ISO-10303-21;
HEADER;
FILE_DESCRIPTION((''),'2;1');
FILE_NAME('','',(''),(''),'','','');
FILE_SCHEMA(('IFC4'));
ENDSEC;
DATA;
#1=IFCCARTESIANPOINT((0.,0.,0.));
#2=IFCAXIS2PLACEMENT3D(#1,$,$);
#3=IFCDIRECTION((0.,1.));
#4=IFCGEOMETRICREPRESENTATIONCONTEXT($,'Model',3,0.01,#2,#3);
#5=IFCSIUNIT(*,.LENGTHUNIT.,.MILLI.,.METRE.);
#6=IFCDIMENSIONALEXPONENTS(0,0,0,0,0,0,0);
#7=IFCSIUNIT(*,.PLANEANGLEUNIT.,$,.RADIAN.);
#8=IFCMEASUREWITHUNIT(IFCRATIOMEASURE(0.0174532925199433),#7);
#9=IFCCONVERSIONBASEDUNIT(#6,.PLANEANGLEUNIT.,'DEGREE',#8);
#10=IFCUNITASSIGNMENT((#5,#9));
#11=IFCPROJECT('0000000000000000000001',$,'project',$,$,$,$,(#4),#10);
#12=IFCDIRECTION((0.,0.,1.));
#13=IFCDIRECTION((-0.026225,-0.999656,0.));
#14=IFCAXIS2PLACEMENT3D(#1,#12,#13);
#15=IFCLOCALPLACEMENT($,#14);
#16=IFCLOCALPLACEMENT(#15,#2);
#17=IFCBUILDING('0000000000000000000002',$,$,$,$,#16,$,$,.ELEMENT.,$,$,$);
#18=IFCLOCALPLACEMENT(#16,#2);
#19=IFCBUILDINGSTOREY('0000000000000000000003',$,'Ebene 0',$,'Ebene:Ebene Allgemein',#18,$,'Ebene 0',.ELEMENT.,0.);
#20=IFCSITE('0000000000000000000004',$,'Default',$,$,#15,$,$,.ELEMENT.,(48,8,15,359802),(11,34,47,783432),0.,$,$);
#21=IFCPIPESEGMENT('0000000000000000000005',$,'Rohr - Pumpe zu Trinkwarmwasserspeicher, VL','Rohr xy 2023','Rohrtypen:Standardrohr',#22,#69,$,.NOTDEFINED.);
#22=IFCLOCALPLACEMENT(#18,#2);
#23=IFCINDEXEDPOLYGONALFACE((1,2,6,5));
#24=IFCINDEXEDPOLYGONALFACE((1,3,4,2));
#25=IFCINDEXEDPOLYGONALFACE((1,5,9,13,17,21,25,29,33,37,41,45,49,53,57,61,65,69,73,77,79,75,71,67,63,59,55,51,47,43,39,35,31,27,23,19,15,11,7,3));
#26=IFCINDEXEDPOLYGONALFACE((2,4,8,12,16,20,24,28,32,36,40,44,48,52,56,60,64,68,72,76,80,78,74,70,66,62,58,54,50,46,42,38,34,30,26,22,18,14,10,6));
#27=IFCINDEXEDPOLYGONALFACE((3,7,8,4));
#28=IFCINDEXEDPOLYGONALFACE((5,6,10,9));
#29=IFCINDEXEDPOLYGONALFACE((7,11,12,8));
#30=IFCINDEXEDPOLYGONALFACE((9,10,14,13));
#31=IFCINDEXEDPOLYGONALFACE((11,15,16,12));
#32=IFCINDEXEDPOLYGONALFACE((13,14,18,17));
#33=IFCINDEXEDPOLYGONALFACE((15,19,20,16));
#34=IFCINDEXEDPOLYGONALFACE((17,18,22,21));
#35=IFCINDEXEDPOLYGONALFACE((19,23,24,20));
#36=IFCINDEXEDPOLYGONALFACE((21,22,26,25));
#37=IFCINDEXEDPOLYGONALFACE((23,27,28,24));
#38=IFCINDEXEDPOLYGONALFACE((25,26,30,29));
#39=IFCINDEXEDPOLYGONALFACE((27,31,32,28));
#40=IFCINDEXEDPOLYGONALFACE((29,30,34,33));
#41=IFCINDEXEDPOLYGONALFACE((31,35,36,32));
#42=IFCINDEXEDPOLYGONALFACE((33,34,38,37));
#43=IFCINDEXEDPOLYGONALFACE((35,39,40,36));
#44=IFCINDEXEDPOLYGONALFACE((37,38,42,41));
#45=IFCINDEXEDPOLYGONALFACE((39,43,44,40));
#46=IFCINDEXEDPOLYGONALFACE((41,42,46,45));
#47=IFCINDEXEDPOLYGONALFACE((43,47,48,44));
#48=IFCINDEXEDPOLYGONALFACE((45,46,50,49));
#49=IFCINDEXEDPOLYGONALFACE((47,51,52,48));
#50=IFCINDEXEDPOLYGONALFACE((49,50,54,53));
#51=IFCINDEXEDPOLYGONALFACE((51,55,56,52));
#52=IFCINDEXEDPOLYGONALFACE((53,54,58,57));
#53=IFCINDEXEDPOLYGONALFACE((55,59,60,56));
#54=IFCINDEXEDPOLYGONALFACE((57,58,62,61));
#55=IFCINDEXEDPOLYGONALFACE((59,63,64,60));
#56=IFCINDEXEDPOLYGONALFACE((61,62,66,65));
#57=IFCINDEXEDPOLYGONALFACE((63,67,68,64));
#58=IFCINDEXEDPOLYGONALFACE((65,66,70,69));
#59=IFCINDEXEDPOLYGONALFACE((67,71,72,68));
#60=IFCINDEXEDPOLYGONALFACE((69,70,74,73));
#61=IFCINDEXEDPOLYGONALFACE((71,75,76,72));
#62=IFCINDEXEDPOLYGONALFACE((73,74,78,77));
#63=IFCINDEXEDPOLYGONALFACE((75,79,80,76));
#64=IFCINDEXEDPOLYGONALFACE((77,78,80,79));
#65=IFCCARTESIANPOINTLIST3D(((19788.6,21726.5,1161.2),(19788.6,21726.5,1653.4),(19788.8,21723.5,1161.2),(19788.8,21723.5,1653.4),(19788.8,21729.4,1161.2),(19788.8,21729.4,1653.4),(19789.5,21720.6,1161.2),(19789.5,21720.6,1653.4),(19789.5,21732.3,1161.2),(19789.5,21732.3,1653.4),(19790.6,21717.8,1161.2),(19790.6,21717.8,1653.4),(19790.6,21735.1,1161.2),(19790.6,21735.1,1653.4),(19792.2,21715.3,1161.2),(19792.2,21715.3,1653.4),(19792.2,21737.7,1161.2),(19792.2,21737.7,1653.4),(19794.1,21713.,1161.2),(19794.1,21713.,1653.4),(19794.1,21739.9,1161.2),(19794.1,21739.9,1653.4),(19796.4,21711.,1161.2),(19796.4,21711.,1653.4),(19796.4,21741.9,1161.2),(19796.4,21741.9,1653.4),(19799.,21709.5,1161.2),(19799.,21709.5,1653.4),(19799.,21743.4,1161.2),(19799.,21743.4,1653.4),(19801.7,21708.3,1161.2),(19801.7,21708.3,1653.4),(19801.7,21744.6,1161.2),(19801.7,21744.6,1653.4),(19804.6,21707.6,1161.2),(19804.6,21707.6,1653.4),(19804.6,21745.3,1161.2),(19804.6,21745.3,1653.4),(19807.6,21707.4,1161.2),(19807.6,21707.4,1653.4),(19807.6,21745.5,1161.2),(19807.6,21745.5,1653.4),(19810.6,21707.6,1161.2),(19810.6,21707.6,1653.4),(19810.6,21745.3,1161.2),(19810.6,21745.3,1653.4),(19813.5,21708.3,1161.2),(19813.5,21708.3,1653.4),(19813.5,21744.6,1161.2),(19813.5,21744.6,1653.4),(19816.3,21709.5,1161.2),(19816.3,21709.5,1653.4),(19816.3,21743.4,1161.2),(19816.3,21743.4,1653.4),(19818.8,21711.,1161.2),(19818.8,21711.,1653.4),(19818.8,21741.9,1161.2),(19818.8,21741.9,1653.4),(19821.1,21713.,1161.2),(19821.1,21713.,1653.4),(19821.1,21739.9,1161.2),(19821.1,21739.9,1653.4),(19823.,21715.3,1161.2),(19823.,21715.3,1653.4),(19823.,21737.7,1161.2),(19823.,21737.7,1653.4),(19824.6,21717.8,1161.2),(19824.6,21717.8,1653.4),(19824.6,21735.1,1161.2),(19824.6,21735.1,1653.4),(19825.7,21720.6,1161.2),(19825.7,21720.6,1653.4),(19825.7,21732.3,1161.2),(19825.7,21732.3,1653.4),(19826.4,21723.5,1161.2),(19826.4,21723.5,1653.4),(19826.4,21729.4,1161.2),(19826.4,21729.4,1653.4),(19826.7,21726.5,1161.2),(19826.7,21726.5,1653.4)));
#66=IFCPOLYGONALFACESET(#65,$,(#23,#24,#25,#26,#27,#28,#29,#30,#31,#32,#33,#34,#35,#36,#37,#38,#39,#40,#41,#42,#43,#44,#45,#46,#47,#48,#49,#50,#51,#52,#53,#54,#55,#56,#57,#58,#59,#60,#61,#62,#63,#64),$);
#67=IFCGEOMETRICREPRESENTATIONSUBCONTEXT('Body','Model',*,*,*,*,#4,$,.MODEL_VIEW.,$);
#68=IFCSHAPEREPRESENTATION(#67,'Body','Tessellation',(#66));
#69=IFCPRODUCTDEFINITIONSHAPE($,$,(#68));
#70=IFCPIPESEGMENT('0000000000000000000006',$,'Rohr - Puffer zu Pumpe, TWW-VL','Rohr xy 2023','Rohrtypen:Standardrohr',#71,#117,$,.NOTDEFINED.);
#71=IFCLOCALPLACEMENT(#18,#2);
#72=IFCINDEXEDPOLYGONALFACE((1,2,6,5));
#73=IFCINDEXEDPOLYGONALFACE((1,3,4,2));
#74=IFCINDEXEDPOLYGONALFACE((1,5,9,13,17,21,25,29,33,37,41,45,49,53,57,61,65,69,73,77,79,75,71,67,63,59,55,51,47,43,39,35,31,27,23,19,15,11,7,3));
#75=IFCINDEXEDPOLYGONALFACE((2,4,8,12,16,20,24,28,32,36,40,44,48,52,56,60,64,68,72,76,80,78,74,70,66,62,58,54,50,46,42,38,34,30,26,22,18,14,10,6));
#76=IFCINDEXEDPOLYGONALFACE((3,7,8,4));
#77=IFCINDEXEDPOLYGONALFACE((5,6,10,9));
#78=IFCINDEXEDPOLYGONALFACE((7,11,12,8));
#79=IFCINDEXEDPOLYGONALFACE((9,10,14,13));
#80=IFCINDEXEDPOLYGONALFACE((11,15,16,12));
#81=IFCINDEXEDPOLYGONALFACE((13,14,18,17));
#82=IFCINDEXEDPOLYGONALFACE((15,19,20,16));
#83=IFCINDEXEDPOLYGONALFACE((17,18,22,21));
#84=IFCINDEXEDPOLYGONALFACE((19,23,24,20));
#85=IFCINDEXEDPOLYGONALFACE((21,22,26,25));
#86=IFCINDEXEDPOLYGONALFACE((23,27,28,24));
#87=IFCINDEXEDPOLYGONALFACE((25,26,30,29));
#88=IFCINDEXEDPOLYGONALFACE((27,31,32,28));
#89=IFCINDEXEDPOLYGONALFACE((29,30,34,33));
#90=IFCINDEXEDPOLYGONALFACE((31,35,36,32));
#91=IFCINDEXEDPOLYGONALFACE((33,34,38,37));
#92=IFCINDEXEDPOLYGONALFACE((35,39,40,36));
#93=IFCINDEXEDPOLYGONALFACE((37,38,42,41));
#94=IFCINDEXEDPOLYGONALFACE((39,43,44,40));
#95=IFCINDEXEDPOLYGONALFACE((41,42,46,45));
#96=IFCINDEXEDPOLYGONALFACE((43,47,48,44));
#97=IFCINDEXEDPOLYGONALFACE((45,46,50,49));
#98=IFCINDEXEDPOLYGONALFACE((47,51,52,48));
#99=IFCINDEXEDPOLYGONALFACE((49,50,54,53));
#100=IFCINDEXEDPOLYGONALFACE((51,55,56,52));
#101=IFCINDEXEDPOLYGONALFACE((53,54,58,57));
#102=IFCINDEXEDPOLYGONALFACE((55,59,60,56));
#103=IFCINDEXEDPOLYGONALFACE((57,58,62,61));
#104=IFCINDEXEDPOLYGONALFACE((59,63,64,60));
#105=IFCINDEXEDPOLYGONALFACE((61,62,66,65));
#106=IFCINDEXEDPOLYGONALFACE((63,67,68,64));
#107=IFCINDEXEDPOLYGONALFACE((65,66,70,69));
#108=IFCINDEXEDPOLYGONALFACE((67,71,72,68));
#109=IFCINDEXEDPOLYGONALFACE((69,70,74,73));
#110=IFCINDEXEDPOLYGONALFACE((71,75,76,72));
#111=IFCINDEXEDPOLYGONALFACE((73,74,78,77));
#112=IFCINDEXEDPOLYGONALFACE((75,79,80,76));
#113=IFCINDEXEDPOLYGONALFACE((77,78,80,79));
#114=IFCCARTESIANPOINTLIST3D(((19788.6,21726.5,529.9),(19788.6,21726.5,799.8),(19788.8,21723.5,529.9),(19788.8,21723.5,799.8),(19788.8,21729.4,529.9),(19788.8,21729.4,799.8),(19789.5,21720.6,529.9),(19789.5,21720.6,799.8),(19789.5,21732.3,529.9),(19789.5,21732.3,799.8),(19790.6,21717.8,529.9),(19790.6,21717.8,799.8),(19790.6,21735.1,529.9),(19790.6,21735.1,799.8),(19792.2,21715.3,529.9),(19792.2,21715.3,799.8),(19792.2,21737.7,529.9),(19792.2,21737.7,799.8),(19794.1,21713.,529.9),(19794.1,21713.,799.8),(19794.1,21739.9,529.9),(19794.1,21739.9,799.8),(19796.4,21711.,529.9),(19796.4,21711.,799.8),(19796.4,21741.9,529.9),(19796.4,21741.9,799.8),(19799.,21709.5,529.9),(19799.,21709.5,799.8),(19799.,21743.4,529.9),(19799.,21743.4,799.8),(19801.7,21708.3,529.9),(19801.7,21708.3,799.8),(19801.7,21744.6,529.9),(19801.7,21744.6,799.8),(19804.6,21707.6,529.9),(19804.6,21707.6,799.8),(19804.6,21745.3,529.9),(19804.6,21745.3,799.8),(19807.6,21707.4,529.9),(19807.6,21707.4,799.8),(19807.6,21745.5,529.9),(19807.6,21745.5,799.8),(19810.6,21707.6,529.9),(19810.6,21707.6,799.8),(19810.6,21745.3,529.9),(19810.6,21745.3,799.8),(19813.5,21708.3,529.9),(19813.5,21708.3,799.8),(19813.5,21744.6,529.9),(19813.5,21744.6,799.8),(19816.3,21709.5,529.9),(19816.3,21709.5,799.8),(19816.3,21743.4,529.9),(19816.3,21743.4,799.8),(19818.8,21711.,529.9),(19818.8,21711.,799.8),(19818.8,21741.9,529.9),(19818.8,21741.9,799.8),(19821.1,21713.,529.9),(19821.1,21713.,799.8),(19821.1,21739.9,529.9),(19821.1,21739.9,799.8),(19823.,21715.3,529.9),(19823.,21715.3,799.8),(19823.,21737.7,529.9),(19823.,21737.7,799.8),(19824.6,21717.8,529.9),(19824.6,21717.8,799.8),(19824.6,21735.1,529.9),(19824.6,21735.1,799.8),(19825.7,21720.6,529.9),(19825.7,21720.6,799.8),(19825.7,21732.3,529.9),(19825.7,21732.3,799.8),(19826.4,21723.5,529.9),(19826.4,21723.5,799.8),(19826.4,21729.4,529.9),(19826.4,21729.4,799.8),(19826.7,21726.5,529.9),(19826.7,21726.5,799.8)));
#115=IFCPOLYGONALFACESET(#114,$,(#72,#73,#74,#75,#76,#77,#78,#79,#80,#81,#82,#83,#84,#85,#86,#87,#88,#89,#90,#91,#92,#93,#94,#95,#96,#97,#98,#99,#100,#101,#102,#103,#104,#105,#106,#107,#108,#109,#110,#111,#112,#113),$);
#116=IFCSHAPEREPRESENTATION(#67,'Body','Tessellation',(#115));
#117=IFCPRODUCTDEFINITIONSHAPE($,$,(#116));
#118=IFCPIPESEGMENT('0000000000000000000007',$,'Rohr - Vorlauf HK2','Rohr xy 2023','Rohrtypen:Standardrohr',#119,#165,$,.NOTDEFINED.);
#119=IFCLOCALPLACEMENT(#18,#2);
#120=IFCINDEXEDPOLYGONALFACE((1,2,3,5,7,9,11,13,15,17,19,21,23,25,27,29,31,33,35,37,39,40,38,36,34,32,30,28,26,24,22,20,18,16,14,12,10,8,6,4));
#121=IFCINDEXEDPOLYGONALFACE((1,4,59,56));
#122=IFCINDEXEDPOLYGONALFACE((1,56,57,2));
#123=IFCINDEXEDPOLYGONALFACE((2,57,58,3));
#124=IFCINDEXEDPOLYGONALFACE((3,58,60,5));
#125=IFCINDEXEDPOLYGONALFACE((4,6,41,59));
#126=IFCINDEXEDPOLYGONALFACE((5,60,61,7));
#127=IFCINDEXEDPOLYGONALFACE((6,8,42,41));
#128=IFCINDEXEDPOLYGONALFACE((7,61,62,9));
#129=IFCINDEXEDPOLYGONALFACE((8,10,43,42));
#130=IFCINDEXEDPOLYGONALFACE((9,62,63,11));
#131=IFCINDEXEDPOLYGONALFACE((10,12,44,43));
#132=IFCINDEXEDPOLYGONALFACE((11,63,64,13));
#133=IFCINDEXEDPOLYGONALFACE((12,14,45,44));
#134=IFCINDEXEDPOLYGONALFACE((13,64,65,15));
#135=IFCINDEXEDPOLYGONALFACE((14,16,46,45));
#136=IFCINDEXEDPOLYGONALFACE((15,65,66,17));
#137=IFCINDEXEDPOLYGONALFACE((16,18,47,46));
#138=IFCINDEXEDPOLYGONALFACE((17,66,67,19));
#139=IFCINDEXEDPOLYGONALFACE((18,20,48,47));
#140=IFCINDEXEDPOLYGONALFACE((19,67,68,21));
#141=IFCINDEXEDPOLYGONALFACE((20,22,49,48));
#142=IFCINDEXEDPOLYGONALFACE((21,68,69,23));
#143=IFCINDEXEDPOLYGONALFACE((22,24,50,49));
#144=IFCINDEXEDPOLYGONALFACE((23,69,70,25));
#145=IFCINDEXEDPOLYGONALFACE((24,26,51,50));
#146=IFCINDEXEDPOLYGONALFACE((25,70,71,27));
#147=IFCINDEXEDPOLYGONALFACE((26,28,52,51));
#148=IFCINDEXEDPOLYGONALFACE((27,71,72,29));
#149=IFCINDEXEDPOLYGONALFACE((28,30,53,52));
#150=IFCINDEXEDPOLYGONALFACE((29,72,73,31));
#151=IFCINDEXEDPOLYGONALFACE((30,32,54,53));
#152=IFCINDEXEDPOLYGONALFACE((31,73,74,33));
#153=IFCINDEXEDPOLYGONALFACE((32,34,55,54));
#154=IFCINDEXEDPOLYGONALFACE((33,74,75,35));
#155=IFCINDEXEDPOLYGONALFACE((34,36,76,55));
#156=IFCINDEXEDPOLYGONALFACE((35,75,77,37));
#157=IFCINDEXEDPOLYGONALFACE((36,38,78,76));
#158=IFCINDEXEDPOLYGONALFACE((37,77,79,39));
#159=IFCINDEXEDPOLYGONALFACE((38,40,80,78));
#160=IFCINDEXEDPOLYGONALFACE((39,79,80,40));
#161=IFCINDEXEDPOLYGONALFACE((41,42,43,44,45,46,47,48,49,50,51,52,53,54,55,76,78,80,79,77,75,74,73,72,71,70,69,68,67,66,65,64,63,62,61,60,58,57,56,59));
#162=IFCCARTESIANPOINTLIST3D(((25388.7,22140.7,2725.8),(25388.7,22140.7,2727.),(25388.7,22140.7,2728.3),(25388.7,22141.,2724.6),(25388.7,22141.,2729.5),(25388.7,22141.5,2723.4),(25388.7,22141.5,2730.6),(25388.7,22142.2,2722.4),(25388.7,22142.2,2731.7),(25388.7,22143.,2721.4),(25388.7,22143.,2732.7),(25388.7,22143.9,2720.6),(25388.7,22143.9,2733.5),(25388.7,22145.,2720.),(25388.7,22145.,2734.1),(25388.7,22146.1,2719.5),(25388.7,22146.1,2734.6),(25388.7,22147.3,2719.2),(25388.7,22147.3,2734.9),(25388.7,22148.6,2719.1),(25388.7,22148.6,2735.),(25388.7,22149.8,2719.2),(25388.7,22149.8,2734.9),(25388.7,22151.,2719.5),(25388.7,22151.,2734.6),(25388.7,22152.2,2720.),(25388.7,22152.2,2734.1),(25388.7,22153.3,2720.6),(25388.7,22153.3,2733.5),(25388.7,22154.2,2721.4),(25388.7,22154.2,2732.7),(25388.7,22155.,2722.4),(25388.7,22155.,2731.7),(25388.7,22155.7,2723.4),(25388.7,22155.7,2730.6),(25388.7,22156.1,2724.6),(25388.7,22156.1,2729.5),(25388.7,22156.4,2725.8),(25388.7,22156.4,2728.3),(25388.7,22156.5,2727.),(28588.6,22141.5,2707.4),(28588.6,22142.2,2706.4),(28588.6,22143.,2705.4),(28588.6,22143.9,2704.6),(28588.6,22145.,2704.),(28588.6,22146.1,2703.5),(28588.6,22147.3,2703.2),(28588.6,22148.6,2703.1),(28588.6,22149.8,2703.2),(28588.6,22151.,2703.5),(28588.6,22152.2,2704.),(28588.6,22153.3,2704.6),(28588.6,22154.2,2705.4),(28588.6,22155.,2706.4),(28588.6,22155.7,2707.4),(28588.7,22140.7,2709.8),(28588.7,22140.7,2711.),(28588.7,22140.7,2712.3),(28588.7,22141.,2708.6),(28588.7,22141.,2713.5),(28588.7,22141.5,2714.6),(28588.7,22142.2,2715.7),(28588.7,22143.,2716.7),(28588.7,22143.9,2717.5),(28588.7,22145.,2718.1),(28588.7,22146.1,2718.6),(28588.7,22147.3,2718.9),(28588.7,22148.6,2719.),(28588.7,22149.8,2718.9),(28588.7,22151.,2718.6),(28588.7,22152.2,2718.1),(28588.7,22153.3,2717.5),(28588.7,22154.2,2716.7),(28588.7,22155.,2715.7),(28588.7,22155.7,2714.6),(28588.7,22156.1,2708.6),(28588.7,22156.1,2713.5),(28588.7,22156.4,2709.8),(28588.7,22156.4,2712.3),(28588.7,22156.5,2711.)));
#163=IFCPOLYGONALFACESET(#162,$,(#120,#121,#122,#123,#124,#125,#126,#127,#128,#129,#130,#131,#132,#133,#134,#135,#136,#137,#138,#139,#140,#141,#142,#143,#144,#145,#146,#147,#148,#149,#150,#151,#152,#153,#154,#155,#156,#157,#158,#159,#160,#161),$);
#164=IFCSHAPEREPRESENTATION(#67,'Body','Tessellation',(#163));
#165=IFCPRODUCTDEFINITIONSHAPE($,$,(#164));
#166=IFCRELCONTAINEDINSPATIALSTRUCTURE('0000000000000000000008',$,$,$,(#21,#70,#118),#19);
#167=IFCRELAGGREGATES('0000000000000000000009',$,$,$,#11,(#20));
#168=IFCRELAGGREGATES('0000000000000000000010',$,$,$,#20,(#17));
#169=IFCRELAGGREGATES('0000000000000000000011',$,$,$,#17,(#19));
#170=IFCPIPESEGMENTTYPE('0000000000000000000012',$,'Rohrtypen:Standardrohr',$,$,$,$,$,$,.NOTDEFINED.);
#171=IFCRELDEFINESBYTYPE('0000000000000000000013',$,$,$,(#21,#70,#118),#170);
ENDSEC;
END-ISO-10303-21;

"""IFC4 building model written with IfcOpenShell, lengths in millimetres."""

from ifc_helpers import new_model, entity, si_unit, converted_unit, direction, frame, origin, place, context, subcontext, project, spatial, indexed_curve, outline, extrude, type_object, element, save


model = new_model("IFC4")

# Units and contexts
model_context = context("Model", 3, precision=0.01, world=origin(), true_north=direction((0.0, 1.0)))
body_context = subcontext(model_context, "Body", "Model", "MODEL_VIEW")
ifc_project = project(units=[si_unit("LENGTHUNIT", "METRE", prefix="MILLI"), converted_unit("PLANEANGLEUNIT", "DEGREE", entity("IfcRatioMeasure", 0.0174532925199433), si_unit("PLANEANGLEUNIT", "RADIAN"), dimensions=[0, 0, 0, 0, 0, 0, 0])], contexts=[model_context])

# Site, building, storey
site_placement = place(None, frame((0.0, 0.0, 0.0), z_axis=(0.0, 0.0, 1.0), x_axis=(-0.026225, -0.999656, 0.0)))
site = spatial("IfcSite", under=ifc_project, at=site_placement, Name="Default", CompositionType="ELEMENT", RefLatitude=(48, 8, 15, 359802), RefLongitude=(11, 34, 47, 783432), RefElevation=0.0)
building_placement = place(site_placement, origin())
building = spatial("IfcBuilding", under=site, at=building_placement, CompositionType="ELEMENT")
storey_placement = place(building_placement, origin())
storey = spatial("IfcBuildingStorey", under=building, at=storey_placement, Name="Ebene 0", ObjectType="Ebene:Ebene Allgemein", LongName="Ebene 0", CompositionType="ELEMENT", Elevation=0.0)

# Pipe segments
pipe_segment_type = type_object("IfcPipeSegmentType", Name="Rohrtypen:Standardrohr", PredefinedType="NOTDEFINED")
pipe_segment_1_placement = place(storey_placement, origin())
element("IfcPipeSegment", 1, at=pipe_segment_1_placement, inside=storey, type_object=pipe_segment_type, Name="Rohr - Pumpe zu Trinkwarmwasserspeicher, VL", Description="Rohr xy 2023", ObjectType="Rohrtypen:Standardrohr", PredefinedType="NOTDEFINED", context=body_context, shape_type="SweptSolid", body=[
    extrude(outline(indexed_curve([(19.1, 0.0), (18.8, 3.0), (18.1, 5.9), (17.0, 8.6), (15.4, 11.2), (13.5, 13.5), (11.2, 15.4), (8.6, 17.0), (5.9, 18.1), (3.0, 18.8), (0.0, 19.0), (-3.0, 18.8), (-5.9, 18.1), (-8.6, 17.0), (-11.2, 15.4), (-13.5, 13.5), (-15.4, 11.2), (-17.0, 8.6), (-18.1, 5.9), (-18.8, 3.0), (-19.1, 0.0), (-18.8, -3.0), (-18.1, -5.9), (-17.0, -8.6), (-15.4, -11.2), (-13.5, -13.5), (-11.2, -15.4), (-8.6, -17.0), (-5.9, -18.1), (-3.0, -18.8), (0.0, -19.0), (3.0, -18.8), (5.9, -18.1), (8.6, -17.0), (11.2, -15.4), (13.5, -13.5), (15.4, -11.2), (17.0, -8.6), (18.1, -5.9), (18.8, -3.0), (19.1, 0.0)], self_intersect=False)), frame((19807.6, 21726.5, 1161.2), z_axis=(0.000002, 0.000002, 1.0), x_axis=(-1.0, 0.0, 0.000002)), (0.0, 0.0, 1.0), 492.1),
])
pipe_segment_2_placement = place(storey_placement, origin())
element("IfcPipeSegment", 2, at=pipe_segment_2_placement, inside=storey, type_object=pipe_segment_type, Name="Rohr - Puffer zu Pumpe, TWW-VL", Description="Rohr xy 2023", ObjectType="Rohrtypen:Standardrohr", PredefinedType="NOTDEFINED", context=body_context, shape_type="SweptSolid", body=[
    extrude(outline(indexed_curve([(19.1, 0.0), (18.8, 3.0), (18.1, 5.9), (17.0, 8.6), (15.4, 11.2), (13.5, 13.5), (11.2, 15.4), (8.6, 17.0), (5.9, 18.1), (3.0, 18.8), (0.0, 19.0), (-3.0, 18.8), (-5.9, 18.1), (-8.6, 17.0), (-11.2, 15.4), (-13.5, 13.5), (-15.4, 11.2), (-17.0, 8.6), (-18.1, 5.9), (-18.8, 3.0), (-19.1, 0.0), (-18.8, -3.0), (-18.1, -5.9), (-17.0, -8.6), (-15.4, -11.2), (-13.5, -13.5), (-11.2, -15.4), (-8.6, -17.0), (-5.9, -18.1), (-3.0, -18.8), (0.0, -19.0), (3.0, -18.8), (5.9, -18.1), (8.6, -17.0), (11.2, -15.4), (13.5, -13.5), (15.4, -11.2), (17.0, -8.6), (18.1, -5.9), (18.8, -3.0), (19.1, 0.0)], self_intersect=False)), frame((19807.6, 21726.5, 529.9), z_axis=(0.000002, 0.000002, 1.0), x_axis=(-1.0, 0.0, 0.000002)), (0.0, 0.0, 1.0), 269.9),
])
pipe_segment_3_placement = place(storey_placement, origin())
element("IfcPipeSegment", 3, at=pipe_segment_3_placement, inside=storey, type_object=pipe_segment_type, Name="Rohr - Vorlauf HK2", Description="Rohr xy 2023", ObjectType="Rohrtypen:Standardrohr", PredefinedType="NOTDEFINED", context=body_context, shape_type="SweptSolid", body=[
    extrude(outline(indexed_curve([(7.9, 0.0), (7.8, 1.2), (7.6, 2.5), (7.1, 3.6), (6.4, 4.7), (5.6, 5.6), (4.7, 6.4), (3.6, 7.1), (2.5, 7.6), (1.2, 7.8), (0.0, 7.9), (-1.2, 7.8), (-2.5, 7.6), (-3.6, 7.1), (-4.7, 6.4), (-5.6, 5.6), (-6.4, 4.7), (-7.1, 3.6), (-7.6, 2.5), (-7.8, 1.2), (-7.9, 0.0), (-7.8, -1.2), (-7.6, -2.5), (-7.1, -3.6), (-6.4, -4.7), (-5.6, -5.6), (-4.7, -6.4), (-3.6, -7.1), (-2.5, -7.6), (-1.2, -7.8), (0.0, -7.9), (1.2, -7.8), (2.5, -7.6), (3.6, -7.1), (4.7, -6.4), (5.6, -5.6), (6.4, -4.7), (7.1, -3.6), (7.6, -2.5), (7.8, -1.2), (7.9, 0.0)], self_intersect=False)), frame((28588.7, 22148.6, 2711.0), z_axis=(-0.999988, 0.0, 0.005), x_axis=(0.0, 1.0, 0.0)), (0.0, 0.0, 1.0), 3200.0),
])

save(model, "model.ifc")
